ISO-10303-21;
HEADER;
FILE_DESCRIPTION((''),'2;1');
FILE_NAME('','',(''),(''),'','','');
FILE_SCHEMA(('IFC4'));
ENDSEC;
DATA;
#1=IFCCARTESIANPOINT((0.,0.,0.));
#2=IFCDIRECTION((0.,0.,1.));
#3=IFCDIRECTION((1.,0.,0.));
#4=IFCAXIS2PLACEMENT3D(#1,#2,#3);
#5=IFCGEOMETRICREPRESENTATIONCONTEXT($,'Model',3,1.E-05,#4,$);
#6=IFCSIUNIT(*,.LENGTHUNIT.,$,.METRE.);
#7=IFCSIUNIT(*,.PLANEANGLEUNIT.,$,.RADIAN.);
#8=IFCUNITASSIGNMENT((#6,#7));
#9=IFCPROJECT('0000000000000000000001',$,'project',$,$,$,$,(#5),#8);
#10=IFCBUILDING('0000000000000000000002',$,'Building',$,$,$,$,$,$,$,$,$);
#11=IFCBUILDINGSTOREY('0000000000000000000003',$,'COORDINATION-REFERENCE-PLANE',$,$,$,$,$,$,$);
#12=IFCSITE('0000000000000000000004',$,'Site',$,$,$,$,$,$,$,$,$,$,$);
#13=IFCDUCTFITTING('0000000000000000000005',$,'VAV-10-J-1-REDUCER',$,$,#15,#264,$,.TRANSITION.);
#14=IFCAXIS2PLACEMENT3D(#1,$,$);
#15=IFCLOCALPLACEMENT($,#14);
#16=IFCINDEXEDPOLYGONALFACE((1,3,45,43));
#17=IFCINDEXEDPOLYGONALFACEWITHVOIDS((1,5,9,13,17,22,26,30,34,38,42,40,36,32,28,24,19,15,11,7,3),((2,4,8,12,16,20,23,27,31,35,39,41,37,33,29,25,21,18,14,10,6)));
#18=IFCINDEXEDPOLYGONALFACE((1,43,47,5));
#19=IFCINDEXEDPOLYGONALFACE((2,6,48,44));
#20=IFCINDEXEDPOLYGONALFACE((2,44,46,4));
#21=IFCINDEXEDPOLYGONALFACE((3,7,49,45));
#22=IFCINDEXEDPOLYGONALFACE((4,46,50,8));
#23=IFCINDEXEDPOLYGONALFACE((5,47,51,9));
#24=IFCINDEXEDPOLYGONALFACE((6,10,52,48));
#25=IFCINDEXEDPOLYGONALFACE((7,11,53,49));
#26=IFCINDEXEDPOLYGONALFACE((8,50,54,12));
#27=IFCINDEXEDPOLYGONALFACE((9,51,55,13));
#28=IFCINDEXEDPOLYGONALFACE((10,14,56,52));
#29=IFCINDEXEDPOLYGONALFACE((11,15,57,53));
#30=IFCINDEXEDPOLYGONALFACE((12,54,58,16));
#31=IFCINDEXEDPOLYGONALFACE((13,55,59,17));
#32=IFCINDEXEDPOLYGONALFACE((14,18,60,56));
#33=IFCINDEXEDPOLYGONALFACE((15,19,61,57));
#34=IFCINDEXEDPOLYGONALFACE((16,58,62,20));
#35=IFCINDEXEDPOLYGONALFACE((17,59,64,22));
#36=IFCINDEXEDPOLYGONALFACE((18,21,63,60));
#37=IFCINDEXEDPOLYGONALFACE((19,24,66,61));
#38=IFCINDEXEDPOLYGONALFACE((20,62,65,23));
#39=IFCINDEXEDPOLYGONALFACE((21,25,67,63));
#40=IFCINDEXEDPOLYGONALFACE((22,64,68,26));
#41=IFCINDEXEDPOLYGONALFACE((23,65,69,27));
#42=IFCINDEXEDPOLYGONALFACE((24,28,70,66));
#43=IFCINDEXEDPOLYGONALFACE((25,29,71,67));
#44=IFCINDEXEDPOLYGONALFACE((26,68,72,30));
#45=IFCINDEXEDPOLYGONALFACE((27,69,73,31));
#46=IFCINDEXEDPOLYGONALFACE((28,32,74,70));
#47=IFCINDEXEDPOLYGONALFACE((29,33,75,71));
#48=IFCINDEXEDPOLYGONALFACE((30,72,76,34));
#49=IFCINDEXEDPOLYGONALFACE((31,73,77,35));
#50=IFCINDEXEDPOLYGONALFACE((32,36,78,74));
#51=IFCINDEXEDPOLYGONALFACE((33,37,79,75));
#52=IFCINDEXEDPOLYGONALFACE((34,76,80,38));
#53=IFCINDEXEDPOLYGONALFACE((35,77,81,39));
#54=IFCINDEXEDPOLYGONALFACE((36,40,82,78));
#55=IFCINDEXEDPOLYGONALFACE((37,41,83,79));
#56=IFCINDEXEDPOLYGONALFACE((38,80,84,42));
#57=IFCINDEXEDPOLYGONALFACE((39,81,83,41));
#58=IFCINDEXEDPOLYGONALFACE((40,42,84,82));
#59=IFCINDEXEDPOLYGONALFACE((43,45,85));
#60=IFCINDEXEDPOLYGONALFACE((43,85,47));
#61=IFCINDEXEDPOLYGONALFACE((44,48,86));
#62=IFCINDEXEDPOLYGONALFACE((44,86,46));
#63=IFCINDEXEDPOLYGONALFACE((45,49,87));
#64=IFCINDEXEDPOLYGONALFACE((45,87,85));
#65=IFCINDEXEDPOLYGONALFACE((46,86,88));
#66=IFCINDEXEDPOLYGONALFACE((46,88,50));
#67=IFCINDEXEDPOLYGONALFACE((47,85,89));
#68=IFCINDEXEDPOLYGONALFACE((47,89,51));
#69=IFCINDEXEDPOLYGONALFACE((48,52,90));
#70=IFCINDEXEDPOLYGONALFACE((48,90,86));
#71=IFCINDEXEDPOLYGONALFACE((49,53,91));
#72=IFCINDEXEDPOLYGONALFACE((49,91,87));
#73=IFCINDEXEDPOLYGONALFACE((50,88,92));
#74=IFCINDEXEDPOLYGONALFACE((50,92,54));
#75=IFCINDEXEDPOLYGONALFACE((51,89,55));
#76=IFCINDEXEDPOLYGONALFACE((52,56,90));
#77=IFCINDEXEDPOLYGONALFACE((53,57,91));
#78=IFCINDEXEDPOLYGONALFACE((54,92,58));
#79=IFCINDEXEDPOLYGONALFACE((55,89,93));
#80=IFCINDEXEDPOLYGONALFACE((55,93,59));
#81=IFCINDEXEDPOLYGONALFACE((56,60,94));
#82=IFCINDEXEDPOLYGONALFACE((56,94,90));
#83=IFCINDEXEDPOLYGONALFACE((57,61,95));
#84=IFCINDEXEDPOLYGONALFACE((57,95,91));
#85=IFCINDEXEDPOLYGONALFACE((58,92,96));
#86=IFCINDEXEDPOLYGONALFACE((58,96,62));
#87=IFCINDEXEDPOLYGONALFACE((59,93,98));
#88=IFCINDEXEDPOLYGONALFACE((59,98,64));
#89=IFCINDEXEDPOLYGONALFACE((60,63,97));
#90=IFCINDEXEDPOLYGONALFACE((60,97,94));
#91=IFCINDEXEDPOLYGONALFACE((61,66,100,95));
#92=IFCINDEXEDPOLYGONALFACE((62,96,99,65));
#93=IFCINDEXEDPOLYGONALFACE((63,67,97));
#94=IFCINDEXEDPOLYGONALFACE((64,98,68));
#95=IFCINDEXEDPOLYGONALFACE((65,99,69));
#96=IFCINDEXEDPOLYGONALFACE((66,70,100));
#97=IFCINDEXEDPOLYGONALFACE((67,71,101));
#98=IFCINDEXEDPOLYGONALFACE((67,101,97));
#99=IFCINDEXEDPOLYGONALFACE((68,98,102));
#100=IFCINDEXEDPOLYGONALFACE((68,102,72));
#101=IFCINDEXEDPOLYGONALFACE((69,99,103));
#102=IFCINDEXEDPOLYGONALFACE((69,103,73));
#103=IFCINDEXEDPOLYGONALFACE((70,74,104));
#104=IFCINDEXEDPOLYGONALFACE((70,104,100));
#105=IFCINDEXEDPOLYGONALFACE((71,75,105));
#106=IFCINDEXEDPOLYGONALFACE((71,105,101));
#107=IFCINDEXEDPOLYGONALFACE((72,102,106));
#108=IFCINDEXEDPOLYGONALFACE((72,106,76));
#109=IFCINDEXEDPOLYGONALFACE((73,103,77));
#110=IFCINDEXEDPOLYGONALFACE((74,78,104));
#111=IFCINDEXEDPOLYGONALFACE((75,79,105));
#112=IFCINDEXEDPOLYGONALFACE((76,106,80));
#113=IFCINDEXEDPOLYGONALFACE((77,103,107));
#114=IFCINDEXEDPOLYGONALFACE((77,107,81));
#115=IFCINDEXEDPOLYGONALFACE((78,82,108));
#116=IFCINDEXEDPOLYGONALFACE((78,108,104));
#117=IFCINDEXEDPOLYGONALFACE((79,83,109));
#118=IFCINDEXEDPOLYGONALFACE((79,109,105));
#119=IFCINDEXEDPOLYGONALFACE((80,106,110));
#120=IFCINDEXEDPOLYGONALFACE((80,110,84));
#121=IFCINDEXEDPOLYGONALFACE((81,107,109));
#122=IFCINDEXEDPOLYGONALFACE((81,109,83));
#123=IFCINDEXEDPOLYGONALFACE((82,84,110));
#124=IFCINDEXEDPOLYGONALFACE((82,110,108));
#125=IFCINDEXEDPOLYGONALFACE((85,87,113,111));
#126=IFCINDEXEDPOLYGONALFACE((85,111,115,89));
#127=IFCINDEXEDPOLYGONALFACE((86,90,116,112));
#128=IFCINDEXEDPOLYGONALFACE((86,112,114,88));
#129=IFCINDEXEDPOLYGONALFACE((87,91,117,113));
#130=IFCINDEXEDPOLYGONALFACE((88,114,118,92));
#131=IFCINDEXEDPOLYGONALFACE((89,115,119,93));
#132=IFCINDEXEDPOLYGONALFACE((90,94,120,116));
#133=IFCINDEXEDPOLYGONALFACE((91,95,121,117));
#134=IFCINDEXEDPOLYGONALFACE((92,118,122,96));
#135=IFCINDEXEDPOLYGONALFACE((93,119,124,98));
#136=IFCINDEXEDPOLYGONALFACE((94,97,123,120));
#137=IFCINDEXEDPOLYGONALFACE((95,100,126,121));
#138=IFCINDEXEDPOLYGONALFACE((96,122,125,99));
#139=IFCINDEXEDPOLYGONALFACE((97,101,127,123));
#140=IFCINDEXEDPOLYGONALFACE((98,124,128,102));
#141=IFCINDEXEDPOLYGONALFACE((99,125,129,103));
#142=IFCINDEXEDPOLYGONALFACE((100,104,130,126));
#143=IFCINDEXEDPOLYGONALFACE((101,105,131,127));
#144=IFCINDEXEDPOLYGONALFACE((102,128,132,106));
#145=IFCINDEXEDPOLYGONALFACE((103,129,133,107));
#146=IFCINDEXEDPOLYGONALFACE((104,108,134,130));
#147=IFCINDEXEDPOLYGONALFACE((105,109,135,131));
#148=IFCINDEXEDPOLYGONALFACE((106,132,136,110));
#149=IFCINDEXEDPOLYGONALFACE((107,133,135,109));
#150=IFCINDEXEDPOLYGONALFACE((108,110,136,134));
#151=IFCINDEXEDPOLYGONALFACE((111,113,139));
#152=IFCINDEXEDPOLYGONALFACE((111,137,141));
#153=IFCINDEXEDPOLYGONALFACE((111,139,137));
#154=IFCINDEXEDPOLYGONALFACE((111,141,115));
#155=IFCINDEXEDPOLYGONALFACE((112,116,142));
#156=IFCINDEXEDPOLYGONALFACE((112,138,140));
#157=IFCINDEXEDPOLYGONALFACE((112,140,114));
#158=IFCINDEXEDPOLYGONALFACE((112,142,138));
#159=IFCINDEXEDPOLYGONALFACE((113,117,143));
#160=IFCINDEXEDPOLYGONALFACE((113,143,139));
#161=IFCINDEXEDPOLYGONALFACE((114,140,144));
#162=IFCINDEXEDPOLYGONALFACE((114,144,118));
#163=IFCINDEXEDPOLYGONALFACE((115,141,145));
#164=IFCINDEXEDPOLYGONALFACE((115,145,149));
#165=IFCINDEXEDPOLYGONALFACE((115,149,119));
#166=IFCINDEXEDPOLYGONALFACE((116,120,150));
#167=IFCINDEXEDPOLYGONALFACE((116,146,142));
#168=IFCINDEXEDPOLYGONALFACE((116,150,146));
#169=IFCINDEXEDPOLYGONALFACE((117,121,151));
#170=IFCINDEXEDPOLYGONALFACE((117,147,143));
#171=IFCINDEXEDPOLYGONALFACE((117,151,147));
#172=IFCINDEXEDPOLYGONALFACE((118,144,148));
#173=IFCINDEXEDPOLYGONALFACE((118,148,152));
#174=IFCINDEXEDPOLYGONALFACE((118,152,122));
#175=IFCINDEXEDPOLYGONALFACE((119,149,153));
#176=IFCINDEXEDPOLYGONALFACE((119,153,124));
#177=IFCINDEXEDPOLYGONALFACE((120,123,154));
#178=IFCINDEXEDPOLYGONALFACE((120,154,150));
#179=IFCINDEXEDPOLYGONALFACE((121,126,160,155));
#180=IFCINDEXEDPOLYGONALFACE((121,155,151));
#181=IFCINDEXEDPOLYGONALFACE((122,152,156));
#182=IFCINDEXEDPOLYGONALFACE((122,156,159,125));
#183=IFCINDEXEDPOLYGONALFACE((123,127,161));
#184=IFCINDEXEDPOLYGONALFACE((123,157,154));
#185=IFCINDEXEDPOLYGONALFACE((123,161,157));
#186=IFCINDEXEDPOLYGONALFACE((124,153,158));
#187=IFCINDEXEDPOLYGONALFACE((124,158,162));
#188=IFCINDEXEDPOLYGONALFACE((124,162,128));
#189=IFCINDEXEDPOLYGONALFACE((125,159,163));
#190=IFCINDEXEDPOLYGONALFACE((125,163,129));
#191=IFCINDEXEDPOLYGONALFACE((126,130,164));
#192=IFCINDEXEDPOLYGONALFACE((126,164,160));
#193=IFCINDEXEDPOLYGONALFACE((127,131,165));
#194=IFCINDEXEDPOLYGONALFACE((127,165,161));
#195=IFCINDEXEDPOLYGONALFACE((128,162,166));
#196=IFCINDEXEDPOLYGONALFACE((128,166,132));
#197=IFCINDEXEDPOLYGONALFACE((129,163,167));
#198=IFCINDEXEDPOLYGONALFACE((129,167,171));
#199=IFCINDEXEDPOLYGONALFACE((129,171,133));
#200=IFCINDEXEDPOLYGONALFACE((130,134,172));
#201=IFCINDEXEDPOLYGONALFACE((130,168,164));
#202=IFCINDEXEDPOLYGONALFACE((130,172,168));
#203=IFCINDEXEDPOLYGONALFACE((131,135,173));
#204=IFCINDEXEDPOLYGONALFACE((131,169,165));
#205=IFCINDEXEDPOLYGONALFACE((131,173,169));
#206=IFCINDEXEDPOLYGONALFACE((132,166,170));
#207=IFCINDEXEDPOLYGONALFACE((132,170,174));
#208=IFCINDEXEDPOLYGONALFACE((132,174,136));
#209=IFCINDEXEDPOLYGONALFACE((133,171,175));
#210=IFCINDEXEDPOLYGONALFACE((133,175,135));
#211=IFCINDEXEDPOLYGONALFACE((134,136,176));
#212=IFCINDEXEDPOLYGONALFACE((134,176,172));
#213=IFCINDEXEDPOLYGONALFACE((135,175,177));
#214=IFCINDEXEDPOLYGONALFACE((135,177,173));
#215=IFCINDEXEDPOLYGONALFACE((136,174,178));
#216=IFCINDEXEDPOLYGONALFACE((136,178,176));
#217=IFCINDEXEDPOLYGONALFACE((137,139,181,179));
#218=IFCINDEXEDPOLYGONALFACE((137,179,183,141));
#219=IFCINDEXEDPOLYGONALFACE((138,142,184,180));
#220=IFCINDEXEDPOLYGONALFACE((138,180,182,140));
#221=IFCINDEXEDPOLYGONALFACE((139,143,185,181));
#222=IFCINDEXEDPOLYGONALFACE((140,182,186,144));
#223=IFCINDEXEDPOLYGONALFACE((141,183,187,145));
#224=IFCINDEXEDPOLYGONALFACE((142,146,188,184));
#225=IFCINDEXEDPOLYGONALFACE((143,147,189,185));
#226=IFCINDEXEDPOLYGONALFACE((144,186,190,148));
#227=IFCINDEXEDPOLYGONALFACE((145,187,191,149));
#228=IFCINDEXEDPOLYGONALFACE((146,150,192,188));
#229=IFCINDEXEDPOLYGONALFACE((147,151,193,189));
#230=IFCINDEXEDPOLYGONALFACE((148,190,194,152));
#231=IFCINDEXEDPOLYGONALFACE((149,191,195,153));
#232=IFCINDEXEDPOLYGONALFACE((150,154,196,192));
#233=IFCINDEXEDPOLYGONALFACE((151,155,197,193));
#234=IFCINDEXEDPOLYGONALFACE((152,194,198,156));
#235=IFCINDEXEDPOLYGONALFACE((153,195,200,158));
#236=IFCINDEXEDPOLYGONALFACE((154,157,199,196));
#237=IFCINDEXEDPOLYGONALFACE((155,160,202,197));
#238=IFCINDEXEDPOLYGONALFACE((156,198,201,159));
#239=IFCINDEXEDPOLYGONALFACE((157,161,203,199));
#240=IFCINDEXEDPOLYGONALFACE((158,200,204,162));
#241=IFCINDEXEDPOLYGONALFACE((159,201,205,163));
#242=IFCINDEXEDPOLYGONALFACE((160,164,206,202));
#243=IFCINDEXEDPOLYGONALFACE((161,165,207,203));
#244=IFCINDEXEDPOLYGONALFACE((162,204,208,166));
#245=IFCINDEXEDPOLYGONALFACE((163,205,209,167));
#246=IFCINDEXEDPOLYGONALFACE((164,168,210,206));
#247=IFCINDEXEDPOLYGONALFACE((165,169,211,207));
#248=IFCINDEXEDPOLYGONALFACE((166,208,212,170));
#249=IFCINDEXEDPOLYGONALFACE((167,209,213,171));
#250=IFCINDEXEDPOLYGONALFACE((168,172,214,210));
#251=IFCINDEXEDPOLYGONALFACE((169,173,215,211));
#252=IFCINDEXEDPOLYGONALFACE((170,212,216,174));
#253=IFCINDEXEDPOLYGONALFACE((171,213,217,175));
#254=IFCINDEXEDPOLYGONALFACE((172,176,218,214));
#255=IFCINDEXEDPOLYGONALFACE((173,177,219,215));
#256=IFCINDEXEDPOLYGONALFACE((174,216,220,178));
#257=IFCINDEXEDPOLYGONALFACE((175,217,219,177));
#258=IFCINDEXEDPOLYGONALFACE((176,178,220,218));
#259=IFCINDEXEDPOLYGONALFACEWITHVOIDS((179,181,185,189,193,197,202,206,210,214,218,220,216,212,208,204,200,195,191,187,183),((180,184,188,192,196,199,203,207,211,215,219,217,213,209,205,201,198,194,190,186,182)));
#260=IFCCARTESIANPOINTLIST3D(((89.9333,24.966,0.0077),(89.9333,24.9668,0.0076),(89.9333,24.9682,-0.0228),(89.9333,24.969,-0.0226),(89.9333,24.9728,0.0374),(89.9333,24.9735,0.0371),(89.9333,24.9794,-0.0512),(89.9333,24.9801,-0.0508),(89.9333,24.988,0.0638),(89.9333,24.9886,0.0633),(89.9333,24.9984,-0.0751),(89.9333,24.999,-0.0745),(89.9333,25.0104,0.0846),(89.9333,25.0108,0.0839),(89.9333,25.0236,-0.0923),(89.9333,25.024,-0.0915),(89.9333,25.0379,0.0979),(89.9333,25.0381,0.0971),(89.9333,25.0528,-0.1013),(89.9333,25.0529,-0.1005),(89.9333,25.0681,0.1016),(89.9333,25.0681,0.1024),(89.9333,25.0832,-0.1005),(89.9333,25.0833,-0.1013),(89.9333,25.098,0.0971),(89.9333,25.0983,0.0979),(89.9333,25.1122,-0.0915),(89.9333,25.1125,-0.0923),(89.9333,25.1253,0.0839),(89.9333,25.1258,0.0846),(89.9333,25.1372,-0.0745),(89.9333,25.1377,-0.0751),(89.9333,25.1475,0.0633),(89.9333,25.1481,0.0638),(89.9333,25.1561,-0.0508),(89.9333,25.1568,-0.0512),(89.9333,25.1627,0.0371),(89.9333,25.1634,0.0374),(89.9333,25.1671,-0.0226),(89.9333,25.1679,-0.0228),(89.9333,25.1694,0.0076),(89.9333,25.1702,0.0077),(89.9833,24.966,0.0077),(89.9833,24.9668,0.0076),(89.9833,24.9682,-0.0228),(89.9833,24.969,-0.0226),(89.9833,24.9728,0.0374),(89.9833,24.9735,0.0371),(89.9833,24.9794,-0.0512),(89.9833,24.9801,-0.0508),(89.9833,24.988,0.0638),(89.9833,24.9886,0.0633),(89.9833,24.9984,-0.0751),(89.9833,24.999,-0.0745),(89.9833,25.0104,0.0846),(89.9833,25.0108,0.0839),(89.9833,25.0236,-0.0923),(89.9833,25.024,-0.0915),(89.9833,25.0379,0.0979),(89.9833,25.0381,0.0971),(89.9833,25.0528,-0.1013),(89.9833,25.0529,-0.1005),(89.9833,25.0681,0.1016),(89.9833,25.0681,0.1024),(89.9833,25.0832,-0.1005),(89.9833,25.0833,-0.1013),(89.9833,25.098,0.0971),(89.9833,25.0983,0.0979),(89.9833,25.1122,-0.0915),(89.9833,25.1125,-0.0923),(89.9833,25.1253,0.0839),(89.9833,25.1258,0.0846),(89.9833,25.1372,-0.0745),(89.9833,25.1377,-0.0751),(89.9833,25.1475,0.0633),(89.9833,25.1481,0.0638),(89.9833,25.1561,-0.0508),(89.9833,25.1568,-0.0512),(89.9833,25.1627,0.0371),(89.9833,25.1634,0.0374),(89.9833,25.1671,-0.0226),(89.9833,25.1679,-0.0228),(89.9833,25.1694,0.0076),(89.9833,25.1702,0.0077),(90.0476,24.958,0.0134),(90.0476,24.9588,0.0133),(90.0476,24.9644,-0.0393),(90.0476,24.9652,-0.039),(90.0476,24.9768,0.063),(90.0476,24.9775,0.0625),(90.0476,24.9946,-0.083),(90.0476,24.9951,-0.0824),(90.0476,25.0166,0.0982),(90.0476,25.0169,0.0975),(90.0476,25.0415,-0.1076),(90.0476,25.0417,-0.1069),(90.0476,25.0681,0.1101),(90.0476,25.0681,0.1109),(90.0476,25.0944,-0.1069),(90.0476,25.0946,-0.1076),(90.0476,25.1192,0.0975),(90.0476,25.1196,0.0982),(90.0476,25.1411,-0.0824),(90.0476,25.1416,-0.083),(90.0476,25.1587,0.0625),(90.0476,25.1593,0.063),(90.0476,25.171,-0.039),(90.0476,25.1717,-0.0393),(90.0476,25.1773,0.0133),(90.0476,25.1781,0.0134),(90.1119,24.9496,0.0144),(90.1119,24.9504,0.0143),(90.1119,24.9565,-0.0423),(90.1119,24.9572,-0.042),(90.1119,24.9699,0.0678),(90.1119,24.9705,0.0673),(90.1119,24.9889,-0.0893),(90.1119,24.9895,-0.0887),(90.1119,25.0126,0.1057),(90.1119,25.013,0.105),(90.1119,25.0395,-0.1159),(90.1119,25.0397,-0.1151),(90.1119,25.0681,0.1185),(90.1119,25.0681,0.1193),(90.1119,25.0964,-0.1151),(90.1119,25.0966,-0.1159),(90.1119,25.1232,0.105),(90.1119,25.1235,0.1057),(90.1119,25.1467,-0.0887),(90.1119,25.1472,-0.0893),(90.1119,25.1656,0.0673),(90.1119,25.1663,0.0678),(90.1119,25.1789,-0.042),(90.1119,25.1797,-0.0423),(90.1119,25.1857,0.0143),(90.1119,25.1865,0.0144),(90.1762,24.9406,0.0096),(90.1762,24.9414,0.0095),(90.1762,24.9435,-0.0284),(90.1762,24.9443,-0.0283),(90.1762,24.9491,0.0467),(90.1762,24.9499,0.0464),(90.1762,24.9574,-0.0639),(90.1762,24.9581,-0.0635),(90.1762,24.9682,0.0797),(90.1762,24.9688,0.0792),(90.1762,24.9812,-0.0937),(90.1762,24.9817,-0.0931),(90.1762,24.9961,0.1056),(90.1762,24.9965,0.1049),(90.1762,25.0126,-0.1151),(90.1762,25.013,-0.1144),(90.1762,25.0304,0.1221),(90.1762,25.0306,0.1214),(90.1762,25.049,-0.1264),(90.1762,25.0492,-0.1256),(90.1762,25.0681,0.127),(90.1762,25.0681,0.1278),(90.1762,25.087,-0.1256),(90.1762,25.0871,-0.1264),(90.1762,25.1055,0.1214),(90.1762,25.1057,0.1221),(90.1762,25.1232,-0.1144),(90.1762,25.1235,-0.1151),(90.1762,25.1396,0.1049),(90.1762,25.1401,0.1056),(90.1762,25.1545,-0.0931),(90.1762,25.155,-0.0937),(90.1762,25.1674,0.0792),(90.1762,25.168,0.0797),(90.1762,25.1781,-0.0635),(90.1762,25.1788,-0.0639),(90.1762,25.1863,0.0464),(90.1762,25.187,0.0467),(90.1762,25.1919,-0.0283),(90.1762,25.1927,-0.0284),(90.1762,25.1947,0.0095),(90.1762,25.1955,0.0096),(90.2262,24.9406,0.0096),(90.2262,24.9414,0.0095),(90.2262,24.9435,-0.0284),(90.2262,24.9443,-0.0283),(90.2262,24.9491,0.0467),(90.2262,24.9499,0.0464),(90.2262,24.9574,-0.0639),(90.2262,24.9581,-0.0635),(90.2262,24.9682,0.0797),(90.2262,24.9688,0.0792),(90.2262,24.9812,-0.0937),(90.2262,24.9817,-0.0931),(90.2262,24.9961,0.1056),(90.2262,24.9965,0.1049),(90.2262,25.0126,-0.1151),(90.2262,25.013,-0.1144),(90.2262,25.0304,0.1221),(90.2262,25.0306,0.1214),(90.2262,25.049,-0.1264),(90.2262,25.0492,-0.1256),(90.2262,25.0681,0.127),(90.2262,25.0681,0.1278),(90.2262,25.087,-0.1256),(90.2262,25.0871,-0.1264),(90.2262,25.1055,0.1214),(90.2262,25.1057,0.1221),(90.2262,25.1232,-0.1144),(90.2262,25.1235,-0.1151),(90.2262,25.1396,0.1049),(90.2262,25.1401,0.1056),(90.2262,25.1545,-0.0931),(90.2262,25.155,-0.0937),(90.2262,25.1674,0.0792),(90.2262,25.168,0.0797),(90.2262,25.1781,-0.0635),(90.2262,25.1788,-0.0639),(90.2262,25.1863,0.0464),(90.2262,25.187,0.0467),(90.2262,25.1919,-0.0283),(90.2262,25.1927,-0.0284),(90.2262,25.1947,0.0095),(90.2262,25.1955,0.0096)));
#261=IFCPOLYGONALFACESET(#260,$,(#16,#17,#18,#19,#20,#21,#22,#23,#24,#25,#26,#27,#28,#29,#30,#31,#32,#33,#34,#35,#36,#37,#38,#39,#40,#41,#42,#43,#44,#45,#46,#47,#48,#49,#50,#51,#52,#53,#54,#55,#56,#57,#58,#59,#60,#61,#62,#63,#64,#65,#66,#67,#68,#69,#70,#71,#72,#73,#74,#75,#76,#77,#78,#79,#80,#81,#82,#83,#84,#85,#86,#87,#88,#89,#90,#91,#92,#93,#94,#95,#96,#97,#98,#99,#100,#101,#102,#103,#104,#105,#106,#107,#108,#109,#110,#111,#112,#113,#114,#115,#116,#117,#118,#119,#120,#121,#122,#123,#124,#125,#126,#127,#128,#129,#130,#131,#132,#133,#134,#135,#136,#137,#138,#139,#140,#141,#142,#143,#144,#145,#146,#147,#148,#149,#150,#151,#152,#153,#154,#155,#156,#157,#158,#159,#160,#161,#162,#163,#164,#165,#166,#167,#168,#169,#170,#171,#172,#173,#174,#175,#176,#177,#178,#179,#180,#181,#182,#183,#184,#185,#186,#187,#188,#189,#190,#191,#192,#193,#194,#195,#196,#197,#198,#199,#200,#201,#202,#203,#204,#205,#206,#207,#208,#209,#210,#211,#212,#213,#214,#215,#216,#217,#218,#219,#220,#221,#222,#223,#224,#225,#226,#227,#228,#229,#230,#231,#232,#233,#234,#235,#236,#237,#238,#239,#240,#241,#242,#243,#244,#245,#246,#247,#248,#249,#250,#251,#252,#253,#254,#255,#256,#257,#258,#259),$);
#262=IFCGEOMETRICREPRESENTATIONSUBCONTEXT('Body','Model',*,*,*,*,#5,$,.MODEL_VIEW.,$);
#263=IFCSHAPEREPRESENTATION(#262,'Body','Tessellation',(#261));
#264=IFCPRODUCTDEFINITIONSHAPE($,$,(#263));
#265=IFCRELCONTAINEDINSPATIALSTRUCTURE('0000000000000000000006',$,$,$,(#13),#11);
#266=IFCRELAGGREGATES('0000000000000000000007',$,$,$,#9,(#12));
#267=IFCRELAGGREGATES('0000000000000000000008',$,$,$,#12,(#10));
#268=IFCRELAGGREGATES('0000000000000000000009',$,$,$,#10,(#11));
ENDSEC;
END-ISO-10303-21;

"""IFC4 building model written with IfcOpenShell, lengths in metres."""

from ifc_helpers import new_model, entity, si_unit, frame, origin_with_axes, place, context, subcontext, project, spatial, element, save


model = new_model("IFC4")

# Units and contexts
model_context = context("Model", 3, precision=1e-05, world=origin_with_axes())
body_context_1 = subcontext(model_context, "Body", "Model", "MODEL_VIEW")
ifc_project = project(units=[si_unit("LENGTHUNIT", "METRE"), si_unit("PLANEANGLEUNIT", "RADIAN")], contexts=[model_context])

# Site, building, storey
site = spatial("IfcSite", under=ifc_project, Name="Site")
building = spatial("IfcBuilding", under=site, Name="Building")
storey = spatial("IfcBuildingStorey", under=building, Name="COORDINATION-REFERENCE-PLANE")

# Duct fitting
for number, where, z_axis, x_axis, name in (
    (1, (90.2262, 25.0681, 0.0), (0.0, -1.0, 0.0), (0.0, 0.0, 1.0), "VAV-10-J-1-REDUCER"),
):
    element("IfcDuctFitting", number, at=place(None, frame(where, z_axis=z_axis, x_axis=x_axis)), inside=storey, Name=name, PredefinedType="TRANSITION", context=body_context_1, shape_type="SweptSolid", body=[
        entity("IfcRevolvedAreaSolid", entity("IfcArbitraryClosedProfileDef", "AREA", None, entity("IfcPolyline", [entity("IfcCartesianPoint", [0.1278, 0.0]), entity("IfcCartesianPoint", [0.1278, 0.05]), entity("IfcCartesianPoint", [0.1024, 0.2429]), entity("IfcCartesianPoint", [0.1024, 0.2929]), entity("IfcCartesianPoint", [0.1016, 0.2929]), entity("IfcCartesianPoint", [0.1016, 0.2429]), entity("IfcCartesianPoint", [0.127, 0.05]), entity("IfcCartesianPoint", [0.127, 0.0]), entity("IfcCartesianPoint", [0.1278, 0.0])])), entity("IfcAxis2Placement3D", entity("IfcCartesianPoint", [0.0, 0.0, 0.0])), entity("IfcAxis1Placement", entity("IfcCartesianPoint", [0.0, 0.0, 0.0]), entity("IfcDirection", [0.0, 1.0, 0.0])), 6.283185),
    ])

save(model, "model.ifc")
